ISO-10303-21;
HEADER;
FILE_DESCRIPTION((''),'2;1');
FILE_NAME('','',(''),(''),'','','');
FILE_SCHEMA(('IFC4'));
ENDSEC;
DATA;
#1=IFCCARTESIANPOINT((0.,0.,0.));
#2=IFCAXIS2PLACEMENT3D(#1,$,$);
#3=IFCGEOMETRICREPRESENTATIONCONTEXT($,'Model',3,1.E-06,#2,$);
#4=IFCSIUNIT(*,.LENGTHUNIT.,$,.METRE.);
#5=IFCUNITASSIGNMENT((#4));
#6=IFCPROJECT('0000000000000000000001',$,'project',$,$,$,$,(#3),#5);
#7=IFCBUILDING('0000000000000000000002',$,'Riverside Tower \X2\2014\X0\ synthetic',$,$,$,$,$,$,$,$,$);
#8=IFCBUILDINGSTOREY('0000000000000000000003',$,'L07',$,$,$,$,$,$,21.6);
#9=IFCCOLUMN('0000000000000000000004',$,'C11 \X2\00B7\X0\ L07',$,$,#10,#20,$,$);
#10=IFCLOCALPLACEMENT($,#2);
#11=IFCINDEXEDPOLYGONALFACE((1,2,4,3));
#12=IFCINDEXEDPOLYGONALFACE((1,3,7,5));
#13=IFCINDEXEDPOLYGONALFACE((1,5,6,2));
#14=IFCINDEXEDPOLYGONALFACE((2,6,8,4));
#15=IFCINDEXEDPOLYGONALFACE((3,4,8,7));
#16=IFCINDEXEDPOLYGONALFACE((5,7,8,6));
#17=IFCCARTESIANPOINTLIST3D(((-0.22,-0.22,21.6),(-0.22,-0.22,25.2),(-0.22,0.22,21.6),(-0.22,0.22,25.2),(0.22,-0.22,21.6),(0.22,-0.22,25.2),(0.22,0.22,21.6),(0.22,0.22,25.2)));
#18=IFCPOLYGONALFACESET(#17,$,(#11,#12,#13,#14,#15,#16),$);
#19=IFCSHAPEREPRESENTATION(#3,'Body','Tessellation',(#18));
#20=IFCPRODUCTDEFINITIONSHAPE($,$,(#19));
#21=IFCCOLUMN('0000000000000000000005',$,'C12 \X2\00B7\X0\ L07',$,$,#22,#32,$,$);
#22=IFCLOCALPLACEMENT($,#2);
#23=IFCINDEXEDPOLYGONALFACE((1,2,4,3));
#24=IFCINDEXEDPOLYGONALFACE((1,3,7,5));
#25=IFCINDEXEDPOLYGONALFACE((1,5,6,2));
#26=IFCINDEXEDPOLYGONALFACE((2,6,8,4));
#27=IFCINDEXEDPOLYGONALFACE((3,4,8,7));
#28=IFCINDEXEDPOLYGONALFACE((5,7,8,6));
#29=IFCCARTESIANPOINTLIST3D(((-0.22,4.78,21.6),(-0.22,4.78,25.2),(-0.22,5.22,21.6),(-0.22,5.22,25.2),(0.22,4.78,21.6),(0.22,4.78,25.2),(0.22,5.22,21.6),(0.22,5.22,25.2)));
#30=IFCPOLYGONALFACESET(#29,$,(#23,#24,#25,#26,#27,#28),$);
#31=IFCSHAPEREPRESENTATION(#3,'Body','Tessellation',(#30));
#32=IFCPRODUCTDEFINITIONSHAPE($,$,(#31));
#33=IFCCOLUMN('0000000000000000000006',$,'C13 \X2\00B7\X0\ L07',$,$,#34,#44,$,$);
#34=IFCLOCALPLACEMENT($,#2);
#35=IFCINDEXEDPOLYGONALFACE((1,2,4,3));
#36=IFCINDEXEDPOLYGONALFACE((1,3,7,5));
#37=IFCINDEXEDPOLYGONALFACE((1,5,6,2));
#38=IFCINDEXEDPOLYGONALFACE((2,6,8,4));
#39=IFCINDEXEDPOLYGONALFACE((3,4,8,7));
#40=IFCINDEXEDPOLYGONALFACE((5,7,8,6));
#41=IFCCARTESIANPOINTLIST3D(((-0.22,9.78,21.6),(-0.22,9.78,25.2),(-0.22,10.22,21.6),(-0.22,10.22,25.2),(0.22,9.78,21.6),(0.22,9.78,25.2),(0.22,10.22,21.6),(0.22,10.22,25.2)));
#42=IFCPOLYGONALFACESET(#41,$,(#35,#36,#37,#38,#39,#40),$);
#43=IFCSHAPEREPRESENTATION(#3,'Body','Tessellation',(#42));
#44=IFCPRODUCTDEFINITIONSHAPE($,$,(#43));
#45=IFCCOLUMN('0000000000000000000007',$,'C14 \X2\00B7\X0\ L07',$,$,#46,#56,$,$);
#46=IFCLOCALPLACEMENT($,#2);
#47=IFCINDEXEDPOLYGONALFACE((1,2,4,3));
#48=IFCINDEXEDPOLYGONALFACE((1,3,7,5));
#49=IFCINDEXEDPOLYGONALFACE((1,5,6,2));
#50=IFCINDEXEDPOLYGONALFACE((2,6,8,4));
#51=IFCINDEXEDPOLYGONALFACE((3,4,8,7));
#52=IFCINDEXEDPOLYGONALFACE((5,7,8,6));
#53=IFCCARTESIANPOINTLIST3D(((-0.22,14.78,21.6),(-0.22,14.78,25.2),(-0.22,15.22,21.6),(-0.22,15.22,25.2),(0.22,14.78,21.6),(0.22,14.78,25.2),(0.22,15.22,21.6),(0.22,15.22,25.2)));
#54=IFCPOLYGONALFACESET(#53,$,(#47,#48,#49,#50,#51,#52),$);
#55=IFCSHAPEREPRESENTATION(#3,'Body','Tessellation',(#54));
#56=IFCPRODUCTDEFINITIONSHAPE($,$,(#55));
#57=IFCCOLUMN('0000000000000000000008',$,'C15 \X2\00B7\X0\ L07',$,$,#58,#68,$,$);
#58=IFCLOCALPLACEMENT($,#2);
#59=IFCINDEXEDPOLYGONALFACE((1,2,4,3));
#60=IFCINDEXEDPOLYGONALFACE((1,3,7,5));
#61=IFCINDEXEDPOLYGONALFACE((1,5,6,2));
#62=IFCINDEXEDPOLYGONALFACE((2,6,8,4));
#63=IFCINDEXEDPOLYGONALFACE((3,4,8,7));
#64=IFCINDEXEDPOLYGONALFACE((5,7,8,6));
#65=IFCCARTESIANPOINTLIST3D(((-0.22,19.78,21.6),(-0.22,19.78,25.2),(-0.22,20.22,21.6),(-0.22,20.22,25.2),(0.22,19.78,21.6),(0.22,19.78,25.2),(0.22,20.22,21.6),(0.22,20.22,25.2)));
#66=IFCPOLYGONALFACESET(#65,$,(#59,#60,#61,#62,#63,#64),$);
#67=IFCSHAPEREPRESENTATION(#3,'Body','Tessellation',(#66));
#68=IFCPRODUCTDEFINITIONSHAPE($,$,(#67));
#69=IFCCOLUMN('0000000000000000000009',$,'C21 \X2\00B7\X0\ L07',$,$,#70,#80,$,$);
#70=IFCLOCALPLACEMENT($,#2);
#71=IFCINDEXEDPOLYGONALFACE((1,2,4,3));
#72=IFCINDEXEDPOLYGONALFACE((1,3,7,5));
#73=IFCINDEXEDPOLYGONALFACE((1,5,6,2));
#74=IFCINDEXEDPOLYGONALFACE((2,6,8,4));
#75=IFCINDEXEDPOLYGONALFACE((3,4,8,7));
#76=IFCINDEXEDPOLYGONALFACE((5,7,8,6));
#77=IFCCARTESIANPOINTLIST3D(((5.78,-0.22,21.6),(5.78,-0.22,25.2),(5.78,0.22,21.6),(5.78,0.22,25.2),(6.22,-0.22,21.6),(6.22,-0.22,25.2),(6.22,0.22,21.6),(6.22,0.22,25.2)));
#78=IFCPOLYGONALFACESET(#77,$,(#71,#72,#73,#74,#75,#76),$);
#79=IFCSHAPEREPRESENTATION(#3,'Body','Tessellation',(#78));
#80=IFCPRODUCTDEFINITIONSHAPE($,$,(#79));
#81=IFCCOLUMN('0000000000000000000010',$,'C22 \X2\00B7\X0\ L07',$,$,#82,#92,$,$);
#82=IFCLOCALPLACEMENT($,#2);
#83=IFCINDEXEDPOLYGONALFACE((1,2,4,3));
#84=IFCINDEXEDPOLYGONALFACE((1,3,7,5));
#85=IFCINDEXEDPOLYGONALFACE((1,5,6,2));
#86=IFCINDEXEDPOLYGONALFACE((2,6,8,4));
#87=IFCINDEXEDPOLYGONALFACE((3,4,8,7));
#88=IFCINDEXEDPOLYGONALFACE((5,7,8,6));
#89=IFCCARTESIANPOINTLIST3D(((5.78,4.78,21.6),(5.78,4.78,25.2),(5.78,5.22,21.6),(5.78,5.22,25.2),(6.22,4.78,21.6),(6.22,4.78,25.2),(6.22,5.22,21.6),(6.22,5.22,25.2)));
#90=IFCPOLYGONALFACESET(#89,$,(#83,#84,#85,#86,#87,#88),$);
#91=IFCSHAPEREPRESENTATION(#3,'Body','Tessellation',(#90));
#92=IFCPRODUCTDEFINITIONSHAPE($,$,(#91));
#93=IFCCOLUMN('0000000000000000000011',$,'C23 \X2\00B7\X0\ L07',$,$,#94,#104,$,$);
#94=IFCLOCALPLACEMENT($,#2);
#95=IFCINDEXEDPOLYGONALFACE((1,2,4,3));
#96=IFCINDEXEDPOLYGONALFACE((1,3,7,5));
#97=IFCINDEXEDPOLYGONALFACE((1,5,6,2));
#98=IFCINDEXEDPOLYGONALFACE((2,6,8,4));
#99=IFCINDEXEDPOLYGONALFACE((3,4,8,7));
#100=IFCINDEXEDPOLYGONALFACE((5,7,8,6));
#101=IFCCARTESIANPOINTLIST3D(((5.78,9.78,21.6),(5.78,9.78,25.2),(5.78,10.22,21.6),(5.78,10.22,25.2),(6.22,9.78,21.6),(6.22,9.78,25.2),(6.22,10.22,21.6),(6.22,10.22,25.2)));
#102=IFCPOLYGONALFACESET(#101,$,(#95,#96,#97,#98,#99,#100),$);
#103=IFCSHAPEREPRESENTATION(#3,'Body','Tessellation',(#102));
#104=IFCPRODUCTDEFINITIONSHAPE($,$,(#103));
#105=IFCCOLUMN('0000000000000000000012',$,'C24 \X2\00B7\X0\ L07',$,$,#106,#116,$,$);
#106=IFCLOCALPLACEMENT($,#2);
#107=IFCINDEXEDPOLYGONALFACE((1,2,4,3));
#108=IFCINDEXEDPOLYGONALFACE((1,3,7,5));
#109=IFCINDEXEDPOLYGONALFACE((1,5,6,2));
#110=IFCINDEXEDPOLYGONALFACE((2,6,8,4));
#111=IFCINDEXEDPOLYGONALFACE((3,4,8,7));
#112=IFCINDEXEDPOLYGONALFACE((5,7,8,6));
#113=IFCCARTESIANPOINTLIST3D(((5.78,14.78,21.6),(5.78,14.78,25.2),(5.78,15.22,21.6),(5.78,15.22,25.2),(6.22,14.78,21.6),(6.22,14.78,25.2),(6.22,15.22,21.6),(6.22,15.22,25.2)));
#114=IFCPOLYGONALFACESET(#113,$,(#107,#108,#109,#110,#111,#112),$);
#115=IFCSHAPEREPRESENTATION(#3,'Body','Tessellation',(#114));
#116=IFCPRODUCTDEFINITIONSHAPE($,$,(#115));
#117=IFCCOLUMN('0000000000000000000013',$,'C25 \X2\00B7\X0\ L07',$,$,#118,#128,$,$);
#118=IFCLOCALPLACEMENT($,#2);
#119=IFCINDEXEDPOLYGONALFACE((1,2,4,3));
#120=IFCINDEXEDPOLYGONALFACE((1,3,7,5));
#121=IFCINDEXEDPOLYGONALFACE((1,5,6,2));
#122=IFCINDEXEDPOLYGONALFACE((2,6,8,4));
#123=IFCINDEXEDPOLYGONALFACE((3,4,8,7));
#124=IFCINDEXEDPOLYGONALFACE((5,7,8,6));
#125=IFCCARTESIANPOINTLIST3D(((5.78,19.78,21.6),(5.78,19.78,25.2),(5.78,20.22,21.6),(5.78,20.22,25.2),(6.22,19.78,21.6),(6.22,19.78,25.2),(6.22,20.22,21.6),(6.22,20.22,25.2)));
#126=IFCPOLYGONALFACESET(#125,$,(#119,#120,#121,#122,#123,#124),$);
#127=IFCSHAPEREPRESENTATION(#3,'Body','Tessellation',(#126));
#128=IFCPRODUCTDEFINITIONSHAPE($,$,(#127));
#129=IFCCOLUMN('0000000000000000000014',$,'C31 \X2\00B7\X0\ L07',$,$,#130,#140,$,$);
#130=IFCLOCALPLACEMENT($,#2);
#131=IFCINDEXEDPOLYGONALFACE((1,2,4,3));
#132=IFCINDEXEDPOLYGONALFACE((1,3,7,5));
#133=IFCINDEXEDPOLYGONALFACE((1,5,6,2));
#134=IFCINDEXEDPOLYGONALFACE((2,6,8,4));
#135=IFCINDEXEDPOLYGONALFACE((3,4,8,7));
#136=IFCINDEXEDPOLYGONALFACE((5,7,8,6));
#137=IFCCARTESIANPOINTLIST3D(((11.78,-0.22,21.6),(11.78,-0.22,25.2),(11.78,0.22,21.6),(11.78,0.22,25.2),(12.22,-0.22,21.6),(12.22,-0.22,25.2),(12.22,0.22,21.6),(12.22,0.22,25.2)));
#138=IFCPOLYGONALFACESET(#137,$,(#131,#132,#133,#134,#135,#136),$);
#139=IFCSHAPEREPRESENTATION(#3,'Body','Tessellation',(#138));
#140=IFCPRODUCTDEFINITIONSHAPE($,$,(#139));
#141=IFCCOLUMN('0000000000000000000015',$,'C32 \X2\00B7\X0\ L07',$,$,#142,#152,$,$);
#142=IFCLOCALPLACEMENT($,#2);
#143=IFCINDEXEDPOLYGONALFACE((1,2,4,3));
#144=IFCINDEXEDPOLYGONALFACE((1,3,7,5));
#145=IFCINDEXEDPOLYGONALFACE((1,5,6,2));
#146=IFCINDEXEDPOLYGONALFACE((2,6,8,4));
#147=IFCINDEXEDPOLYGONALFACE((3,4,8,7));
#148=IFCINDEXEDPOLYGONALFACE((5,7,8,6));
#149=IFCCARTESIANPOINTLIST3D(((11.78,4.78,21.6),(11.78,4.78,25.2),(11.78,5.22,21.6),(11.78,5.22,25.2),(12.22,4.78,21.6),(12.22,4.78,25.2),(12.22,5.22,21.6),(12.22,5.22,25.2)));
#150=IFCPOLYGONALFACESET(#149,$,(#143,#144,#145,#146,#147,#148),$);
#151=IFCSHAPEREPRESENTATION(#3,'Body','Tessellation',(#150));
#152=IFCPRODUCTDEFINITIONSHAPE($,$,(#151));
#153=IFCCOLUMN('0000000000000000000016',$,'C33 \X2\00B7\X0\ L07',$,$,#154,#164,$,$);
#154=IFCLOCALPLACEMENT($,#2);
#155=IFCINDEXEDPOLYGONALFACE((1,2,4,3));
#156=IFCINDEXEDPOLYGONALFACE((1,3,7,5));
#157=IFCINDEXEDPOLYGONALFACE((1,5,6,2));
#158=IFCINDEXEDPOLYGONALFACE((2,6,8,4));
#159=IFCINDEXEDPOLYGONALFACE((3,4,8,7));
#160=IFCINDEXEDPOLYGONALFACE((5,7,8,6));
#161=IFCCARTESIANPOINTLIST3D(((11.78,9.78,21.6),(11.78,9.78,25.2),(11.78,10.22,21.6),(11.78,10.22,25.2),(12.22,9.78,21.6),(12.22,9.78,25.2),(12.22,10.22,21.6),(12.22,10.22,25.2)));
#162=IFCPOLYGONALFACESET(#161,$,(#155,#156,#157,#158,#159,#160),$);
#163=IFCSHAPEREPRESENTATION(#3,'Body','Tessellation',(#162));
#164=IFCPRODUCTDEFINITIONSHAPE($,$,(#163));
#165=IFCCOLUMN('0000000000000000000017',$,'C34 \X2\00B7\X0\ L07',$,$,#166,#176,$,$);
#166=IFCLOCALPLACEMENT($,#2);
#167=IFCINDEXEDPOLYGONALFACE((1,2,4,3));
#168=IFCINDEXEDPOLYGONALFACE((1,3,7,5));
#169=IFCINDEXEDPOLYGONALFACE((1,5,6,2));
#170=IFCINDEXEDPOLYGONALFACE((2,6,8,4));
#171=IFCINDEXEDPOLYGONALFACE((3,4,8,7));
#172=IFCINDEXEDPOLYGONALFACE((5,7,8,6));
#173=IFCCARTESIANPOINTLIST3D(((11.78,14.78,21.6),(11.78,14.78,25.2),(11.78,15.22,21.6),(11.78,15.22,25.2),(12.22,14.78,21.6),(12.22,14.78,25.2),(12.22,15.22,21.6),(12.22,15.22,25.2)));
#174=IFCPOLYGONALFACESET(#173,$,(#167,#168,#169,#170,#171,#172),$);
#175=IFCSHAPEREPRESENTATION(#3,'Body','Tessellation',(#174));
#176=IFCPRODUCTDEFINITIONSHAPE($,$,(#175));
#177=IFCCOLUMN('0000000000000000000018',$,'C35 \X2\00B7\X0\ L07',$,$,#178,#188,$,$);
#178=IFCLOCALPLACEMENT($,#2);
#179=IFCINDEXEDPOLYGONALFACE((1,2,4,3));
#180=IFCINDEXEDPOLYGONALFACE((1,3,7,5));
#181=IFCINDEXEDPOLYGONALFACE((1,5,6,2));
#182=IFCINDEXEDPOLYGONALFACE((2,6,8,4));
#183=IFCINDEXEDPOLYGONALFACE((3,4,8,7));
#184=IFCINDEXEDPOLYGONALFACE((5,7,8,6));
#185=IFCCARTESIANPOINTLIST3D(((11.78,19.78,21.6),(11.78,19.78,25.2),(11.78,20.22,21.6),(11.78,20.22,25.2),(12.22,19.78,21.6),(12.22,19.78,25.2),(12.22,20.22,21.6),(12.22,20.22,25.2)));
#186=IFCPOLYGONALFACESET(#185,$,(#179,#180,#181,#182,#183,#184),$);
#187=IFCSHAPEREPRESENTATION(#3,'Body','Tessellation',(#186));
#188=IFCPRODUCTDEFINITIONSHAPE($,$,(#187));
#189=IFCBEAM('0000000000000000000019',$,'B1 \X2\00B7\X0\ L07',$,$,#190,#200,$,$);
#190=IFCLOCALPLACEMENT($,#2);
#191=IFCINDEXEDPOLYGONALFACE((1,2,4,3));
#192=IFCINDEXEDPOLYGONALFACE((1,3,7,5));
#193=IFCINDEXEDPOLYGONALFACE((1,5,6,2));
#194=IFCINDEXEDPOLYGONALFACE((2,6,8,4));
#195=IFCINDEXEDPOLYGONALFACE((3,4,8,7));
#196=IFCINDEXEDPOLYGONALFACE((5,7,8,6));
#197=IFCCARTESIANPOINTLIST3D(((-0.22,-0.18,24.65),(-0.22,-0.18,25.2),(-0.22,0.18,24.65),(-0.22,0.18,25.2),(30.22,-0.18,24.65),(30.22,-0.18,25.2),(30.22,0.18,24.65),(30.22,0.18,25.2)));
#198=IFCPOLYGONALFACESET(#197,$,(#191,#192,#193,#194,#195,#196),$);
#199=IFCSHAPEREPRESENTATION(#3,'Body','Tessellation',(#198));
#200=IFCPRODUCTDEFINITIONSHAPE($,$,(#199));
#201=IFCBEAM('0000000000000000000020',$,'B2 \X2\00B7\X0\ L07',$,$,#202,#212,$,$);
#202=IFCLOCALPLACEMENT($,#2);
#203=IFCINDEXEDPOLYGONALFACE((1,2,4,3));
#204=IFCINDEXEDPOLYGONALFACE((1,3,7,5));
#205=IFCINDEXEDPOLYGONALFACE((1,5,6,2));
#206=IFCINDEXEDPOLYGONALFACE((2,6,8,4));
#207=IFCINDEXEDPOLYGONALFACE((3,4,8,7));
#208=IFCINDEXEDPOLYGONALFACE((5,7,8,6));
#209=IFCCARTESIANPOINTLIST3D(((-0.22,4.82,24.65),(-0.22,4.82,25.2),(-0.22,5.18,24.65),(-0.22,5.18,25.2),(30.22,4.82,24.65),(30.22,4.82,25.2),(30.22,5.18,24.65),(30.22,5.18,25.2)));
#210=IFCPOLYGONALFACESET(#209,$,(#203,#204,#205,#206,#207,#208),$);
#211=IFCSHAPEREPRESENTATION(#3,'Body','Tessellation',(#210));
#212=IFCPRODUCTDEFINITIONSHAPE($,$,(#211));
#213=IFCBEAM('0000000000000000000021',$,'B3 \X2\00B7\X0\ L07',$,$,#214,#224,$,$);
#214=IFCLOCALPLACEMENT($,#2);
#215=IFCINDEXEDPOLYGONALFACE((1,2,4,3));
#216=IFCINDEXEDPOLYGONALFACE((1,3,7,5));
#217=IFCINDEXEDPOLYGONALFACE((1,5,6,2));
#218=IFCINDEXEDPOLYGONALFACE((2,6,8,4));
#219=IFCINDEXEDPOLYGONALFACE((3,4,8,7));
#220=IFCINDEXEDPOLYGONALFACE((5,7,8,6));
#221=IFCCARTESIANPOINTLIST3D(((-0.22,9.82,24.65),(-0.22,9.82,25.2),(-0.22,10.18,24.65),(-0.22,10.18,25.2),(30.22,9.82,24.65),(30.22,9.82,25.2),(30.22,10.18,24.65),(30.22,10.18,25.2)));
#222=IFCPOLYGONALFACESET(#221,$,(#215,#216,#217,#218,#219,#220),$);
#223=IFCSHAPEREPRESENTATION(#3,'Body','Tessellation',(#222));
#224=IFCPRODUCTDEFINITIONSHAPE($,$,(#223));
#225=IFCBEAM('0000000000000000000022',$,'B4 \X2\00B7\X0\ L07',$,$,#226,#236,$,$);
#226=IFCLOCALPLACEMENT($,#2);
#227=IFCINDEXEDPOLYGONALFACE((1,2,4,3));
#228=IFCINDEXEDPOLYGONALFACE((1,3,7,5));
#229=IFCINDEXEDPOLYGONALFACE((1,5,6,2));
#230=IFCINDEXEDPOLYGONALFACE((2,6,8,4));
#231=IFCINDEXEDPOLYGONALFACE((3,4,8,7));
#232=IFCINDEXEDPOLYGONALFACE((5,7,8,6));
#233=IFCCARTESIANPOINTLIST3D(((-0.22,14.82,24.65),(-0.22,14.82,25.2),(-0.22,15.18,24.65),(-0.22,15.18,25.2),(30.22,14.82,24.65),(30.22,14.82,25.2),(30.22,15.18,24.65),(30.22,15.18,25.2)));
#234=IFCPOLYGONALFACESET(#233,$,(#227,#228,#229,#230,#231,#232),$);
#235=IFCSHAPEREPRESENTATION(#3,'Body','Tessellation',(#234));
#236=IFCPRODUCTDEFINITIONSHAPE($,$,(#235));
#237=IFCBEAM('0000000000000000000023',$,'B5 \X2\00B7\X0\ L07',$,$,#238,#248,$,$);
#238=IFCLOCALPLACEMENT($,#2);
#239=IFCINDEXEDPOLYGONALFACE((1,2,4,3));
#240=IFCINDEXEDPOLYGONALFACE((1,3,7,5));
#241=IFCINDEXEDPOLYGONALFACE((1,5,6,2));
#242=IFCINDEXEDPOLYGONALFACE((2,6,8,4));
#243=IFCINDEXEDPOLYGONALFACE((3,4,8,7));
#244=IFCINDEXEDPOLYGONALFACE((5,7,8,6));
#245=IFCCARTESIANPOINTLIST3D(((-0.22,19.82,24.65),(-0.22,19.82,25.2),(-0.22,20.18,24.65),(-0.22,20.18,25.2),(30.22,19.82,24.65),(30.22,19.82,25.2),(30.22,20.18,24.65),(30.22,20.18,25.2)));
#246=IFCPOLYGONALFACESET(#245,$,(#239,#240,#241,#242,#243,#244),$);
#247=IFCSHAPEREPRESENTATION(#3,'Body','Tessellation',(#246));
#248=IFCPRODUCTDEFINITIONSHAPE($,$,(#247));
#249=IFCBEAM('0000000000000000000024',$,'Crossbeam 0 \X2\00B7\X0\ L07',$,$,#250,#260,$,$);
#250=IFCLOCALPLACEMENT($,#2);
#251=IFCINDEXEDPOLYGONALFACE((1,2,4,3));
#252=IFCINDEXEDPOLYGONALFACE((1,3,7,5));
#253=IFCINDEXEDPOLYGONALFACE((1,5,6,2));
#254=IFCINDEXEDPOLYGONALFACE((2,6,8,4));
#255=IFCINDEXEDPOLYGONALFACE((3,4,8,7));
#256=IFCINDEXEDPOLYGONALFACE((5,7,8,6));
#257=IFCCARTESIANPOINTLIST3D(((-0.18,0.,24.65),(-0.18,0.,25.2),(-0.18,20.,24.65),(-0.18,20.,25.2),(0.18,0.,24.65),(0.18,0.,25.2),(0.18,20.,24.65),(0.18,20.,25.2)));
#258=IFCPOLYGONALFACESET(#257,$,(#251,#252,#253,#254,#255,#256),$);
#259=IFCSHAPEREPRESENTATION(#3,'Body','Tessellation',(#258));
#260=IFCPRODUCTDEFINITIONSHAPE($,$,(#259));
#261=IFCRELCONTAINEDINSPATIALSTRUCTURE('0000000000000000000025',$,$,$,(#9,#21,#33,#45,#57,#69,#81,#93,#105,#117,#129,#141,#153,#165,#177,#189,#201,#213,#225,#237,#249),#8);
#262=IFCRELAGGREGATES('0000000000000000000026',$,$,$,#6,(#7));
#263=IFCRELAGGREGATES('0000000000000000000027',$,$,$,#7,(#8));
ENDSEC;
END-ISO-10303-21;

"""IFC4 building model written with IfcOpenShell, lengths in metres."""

from ifc_helpers import new_model, si_unit, frame, origin, place, context, project, spatial, rectangle, extrude, element, save


model = new_model("IFC4")

# Units and contexts
model_context = context("Model", 3, precision=1e-06, world=origin())
ifc_project = project(units=[si_unit("LENGTHUNIT", "METRE")], contexts=[model_context])

# Building, storey
building = spatial("IfcBuilding", under=ifc_project, Name="Riverside Tower — synthetic")
storey = spatial("IfcBuildingStorey", under=building, Name="L07", Elevation=21.6)

# Columns
for number, where, name in (
    (1, (0.0, 0.0, 21.6), "C11 · L07"),
    (2, (0.0, 5.0, 21.6), "C12 · L07"),
    (3, (0.0, 10.0, 21.6), "C13 · L07"),
    (4, (0.0, 15.0, 21.6), "C14 · L07"),
    (5, (0.0, 20.0, 21.6), "C15 · L07"),
    (6, (6.0, 0.0, 21.6), "C21 · L07"),
    (7, (6.0, 5.0, 21.6), "C22 · L07"),
    (8, (6.0, 10.0, 21.6), "C23 · L07"),
    (9, (6.0, 15.0, 21.6), "C24 · L07"),
    (10, (6.0, 20.0, 21.6), "C25 · L07"),
    (11, (12.0, 0.0, 21.6), "C31 · L07"),
    (12, (12.0, 5.0, 21.6), "C32 · L07"),
    (13, (12.0, 10.0, 21.6), "C33 · L07"),
    (14, (12.0, 15.0, 21.6), "C34 · L07"),
    (15, (12.0, 20.0, 21.6), "C35 · L07"),
):
    element("IfcColumn", number, at=place(None, frame(where)), inside=storey, Name=name, context=model_context, shape_type="SweptSolid", body=[
        extrude(rectangle(XDim=0.44, YDim=0.44), origin(), (0.0, 0.0, 1.0), 3.6),
    ])

# Beams
for number, where, name in (
    (16, (15.0, 0.0, 24.65), "B1 · L07"),
    (17, (15.0, 5.0, 24.65), "B2 · L07"),
    (18, (15.0, 10.0, 24.65), "B3 · L07"),
    (19, (15.0, 15.0, 24.65), "B4 · L07"),
    (20, (15.0, 20.0, 24.65), "B5 · L07"),
):
    element("IfcBeam", number, at=place(None, frame(where)), inside=storey, Name=name, context=model_context, shape_type="SweptSolid", body=[
        extrude(rectangle(XDim=30.44, YDim=0.36), origin(), (0.0, 0.0, 1.0), 0.55),
    ])
for number, where, name in (
    (21, (0.0, 10.0, 24.65), "Crossbeam 0 · L07"),
):
    element("IfcBeam", number, at=place(None, frame(where)), inside=storey, Name=name, context=model_context, shape_type="SweptSolid", body=[
        extrude(rectangle(XDim=0.36, YDim=20.0), origin(), (0.0, 0.0, 1.0), 0.55),
    ])

save(model, "model.ifc")
